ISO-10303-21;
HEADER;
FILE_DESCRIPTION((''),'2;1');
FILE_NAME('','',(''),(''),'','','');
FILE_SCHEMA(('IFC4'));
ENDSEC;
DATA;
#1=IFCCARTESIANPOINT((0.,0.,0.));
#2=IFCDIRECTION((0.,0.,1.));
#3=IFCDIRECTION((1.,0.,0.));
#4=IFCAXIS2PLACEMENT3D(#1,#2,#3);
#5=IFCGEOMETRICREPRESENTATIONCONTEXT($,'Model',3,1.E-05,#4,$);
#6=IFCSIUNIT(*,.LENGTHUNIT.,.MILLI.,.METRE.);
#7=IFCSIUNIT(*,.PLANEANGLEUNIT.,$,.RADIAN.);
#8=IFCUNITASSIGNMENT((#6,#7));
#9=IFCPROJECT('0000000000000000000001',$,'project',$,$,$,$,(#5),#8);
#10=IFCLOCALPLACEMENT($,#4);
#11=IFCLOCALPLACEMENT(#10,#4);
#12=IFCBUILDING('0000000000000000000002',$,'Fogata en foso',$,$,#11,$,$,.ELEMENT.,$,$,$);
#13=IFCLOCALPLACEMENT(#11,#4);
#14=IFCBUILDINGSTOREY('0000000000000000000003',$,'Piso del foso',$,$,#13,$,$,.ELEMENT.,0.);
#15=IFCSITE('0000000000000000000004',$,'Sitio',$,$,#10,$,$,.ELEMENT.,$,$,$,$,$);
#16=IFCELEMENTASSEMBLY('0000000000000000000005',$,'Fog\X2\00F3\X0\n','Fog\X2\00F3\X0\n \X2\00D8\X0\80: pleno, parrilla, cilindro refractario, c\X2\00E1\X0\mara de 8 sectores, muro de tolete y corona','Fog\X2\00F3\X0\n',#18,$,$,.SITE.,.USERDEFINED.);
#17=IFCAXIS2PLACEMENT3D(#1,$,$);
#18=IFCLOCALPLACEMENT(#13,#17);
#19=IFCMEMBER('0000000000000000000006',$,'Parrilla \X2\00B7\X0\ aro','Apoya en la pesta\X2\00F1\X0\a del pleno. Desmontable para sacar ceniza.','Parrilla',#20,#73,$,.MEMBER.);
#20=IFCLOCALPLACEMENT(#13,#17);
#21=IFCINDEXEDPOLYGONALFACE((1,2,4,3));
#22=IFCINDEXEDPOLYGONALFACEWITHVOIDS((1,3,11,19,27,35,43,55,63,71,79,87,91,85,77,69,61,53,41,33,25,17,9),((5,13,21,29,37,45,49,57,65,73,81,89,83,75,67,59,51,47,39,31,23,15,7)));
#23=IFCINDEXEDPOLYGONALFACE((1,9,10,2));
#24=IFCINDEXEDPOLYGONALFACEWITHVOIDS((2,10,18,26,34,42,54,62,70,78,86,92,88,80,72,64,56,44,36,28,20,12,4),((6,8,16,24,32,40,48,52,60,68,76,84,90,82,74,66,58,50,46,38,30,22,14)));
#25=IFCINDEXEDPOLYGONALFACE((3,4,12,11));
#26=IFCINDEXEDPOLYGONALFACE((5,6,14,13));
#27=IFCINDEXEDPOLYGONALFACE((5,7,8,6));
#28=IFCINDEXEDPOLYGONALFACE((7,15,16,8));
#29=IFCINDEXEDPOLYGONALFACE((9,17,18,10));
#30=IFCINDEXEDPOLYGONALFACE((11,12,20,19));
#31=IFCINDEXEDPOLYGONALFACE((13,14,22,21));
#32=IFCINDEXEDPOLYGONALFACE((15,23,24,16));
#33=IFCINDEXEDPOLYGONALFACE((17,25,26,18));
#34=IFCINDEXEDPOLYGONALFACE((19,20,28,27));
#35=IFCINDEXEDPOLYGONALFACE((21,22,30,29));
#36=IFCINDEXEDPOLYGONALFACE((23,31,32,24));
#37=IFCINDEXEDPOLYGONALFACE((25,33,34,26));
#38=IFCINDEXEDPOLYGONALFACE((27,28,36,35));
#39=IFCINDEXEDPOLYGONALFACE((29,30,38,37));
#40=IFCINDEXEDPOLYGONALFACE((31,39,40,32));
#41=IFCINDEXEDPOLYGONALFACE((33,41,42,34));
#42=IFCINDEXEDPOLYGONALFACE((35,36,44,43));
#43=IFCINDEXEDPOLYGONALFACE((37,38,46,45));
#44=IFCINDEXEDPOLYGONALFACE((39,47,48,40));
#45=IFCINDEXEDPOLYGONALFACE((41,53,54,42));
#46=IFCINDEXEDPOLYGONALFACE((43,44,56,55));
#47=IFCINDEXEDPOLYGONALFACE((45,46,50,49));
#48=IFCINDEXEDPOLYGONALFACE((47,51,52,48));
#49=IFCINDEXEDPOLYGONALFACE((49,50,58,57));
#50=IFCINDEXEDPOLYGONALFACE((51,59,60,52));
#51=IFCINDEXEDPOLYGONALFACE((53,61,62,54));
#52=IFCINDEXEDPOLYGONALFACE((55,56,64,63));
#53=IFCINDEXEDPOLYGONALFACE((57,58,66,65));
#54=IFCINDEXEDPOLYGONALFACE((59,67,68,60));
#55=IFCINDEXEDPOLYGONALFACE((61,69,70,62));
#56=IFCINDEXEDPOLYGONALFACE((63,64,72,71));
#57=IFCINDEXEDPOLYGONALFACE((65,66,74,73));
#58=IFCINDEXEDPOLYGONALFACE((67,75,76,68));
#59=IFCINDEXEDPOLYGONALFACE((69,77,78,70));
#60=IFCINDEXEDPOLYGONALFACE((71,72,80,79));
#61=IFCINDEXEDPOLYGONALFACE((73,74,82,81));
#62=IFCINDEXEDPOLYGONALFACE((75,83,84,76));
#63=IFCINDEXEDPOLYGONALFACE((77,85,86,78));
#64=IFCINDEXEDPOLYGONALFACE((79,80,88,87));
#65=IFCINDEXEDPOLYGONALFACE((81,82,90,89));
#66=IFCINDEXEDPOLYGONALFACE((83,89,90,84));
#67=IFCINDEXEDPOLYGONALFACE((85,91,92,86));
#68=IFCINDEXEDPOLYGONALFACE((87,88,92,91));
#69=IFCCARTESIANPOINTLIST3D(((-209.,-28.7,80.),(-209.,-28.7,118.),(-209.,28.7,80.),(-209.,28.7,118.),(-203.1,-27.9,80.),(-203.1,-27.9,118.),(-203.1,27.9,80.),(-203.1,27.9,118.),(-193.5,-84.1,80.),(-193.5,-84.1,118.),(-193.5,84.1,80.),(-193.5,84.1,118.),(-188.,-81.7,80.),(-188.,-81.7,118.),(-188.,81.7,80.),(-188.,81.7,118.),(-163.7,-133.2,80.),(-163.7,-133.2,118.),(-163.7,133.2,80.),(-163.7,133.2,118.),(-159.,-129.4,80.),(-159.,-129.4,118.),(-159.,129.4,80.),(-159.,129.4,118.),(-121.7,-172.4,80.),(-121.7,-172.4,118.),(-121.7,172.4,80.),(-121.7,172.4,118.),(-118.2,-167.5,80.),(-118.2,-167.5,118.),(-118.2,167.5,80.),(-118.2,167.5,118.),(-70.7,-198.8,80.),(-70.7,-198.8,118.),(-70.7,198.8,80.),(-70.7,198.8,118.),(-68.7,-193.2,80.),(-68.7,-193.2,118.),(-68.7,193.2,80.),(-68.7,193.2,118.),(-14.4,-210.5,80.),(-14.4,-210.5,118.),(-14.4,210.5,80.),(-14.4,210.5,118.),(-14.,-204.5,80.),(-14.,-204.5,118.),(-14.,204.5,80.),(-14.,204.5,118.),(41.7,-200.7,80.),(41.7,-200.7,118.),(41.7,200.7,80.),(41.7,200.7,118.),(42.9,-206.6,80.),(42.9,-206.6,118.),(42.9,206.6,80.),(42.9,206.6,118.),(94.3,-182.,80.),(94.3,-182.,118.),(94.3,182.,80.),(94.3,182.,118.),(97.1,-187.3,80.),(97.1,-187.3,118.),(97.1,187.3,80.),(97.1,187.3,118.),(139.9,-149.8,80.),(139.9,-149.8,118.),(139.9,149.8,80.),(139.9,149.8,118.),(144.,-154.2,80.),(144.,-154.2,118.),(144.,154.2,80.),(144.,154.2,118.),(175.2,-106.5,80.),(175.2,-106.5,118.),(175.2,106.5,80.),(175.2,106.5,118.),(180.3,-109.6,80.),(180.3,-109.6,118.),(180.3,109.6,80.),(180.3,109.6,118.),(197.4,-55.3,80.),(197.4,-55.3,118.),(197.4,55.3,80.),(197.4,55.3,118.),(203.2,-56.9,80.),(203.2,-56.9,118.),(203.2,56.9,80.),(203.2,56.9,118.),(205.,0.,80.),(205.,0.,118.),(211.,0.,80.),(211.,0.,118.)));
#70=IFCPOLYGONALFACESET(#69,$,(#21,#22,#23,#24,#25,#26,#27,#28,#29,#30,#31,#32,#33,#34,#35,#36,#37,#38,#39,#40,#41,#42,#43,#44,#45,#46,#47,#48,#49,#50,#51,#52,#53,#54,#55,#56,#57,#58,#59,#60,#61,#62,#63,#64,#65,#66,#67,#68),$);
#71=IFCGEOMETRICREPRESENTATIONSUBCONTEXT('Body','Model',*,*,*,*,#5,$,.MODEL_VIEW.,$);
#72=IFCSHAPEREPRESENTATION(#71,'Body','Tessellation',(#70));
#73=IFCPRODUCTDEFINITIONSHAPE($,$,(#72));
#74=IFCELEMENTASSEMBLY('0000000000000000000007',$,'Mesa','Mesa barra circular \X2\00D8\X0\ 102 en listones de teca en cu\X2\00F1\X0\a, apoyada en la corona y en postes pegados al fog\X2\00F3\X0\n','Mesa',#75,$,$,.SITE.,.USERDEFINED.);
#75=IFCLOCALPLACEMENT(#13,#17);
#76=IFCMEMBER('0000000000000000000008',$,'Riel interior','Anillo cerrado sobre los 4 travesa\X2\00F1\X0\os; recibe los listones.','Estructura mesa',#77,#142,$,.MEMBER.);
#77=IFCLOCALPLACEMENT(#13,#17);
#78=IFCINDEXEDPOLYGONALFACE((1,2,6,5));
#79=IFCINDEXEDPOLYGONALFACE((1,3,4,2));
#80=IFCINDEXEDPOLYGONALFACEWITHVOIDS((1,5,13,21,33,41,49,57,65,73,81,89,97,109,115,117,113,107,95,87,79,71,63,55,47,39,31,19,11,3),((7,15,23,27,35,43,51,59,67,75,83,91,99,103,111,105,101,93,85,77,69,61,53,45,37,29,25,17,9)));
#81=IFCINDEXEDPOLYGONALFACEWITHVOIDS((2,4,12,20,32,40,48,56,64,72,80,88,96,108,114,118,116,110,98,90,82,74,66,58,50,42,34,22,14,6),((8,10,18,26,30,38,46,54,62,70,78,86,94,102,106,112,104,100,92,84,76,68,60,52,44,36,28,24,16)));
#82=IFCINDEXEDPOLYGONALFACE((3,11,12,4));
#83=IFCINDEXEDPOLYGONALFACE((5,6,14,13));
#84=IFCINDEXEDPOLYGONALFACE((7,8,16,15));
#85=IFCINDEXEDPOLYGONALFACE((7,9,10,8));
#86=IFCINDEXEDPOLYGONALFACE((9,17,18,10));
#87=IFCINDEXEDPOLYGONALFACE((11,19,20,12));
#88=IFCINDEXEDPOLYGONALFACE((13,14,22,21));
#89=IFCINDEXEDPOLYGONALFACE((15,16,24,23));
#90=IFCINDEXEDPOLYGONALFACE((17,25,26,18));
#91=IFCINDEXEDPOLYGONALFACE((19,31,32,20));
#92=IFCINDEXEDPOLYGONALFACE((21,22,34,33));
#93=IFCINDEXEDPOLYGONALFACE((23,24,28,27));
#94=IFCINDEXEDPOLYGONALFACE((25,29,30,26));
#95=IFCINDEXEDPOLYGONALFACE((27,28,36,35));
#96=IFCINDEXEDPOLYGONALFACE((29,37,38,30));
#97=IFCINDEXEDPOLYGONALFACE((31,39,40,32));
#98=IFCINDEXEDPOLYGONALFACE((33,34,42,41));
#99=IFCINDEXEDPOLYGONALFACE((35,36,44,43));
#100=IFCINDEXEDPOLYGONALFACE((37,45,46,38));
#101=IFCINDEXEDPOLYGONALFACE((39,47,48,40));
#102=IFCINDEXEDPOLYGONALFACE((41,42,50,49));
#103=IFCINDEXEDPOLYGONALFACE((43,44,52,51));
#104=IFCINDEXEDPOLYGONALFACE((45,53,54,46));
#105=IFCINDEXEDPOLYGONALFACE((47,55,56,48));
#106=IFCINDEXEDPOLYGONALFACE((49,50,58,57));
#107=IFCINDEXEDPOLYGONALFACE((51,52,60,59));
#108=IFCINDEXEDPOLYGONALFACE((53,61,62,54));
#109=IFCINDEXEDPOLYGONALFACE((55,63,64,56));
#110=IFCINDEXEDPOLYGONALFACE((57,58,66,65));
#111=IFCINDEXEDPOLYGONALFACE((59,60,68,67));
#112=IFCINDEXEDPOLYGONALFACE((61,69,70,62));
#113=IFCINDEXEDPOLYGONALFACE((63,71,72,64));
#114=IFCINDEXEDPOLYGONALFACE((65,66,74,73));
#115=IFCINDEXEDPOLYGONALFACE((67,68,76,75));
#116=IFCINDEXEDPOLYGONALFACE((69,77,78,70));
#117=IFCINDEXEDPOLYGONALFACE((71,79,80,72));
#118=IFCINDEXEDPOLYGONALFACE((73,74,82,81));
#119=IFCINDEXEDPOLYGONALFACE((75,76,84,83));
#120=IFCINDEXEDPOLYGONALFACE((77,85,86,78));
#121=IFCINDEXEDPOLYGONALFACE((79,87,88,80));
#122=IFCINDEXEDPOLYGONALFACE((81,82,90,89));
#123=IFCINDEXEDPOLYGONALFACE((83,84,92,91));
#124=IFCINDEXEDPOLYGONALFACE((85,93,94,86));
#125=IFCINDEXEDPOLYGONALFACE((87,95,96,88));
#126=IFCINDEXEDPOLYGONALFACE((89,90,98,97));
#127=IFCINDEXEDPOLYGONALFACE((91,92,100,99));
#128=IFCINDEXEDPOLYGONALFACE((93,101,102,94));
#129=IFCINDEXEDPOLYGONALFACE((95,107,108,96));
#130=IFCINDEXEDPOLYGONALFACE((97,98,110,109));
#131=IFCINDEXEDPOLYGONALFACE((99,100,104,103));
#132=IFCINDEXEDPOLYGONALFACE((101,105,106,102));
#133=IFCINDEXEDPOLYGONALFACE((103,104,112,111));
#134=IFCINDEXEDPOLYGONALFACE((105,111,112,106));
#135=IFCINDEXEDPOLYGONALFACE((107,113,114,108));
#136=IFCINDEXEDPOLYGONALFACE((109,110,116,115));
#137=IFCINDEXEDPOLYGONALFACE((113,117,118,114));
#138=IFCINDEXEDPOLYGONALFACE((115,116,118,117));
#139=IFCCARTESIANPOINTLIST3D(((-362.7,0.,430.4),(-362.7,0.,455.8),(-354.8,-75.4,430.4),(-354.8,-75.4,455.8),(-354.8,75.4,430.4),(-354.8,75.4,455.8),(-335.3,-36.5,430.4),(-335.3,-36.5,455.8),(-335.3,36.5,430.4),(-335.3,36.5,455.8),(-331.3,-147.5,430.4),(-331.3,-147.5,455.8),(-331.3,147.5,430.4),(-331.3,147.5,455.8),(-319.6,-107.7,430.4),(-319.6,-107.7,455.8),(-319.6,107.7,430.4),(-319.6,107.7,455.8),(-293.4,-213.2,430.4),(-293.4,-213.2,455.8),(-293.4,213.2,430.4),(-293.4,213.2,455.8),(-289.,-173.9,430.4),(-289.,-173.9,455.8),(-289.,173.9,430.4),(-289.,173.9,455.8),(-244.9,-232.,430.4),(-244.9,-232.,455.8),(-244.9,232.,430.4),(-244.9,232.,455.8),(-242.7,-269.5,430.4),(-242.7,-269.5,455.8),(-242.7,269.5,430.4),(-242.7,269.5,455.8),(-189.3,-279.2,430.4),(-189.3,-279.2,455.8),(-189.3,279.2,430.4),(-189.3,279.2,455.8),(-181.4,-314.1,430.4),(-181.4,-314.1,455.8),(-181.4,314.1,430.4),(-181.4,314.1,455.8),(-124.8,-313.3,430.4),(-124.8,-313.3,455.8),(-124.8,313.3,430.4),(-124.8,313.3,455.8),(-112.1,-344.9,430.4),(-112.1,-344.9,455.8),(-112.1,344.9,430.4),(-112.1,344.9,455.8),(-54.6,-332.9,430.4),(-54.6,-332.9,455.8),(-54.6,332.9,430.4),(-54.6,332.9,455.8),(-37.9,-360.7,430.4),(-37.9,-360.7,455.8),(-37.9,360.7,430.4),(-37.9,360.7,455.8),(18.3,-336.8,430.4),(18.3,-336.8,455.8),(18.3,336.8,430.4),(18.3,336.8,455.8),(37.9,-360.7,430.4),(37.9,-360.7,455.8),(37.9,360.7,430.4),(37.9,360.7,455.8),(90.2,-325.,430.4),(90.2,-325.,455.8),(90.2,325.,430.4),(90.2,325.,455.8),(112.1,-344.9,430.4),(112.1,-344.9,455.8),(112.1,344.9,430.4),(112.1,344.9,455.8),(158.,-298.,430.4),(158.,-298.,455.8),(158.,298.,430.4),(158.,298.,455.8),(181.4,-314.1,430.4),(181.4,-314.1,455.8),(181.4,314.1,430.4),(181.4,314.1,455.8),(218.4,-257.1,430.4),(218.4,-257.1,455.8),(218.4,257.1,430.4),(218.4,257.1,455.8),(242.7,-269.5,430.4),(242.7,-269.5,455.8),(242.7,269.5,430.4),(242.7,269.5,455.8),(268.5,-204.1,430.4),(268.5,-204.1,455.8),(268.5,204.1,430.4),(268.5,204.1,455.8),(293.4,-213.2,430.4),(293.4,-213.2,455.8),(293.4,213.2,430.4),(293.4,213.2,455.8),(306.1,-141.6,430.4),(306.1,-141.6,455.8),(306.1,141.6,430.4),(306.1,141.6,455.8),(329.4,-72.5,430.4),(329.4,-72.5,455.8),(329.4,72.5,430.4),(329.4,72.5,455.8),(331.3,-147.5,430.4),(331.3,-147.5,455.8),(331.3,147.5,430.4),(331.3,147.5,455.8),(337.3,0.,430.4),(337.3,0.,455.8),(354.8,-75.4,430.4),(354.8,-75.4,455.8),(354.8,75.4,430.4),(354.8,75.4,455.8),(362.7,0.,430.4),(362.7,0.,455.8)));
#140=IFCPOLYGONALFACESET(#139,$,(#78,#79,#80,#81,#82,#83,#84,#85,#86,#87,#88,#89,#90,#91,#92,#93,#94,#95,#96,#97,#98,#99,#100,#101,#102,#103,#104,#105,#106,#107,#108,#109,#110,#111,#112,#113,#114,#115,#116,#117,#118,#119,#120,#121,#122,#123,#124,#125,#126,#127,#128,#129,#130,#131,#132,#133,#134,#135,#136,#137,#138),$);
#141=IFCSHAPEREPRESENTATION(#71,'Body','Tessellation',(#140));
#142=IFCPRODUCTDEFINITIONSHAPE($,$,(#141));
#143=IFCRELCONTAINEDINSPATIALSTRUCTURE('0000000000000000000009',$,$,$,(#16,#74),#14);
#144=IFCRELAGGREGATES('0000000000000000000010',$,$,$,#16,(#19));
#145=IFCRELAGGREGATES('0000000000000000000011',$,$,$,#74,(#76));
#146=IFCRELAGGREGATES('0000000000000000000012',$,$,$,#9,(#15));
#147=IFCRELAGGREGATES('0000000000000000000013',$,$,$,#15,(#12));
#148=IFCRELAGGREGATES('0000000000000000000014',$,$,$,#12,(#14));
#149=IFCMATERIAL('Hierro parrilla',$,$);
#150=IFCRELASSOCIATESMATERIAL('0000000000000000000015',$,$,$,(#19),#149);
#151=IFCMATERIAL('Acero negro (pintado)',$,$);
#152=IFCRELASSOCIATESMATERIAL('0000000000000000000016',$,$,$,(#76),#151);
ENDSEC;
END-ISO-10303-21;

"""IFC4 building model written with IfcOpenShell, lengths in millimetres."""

from ifc_helpers import new_model, si_unit, frame, origin_with_axes, origin_2d, place, context, subcontext, project, spatial, hollow_circle, extrude, material, element, aggregate, save


model = new_model("IFC4")

# Units and contexts
model_context = context("Model", 3, precision=1e-05, world=origin_with_axes())
body_context = subcontext(model_context, "Body", "Model", "MODEL_VIEW")
ifc_project = project(units=[si_unit("LENGTHUNIT", "METRE", prefix="MILLI"), si_unit("PLANEANGLEUNIT", "RADIAN")], contexts=[model_context])

# Site, building, storey
site_placement = place(None, origin_with_axes())
site = spatial("IfcSite", under=ifc_project, at=site_placement, Name="Sitio", CompositionType="ELEMENT")
building_placement = place(site_placement, origin_with_axes())
building = spatial("IfcBuilding", under=site, at=building_placement, Name="Fogata en foso", CompositionType="ELEMENT")
storey_placement = place(building_placement, origin_with_axes())
storey = spatial("IfcBuildingStorey", under=building, at=storey_placement, Name="Piso del foso", CompositionType="ELEMENT", Elevation=0.0)

# Element assembly, member
assembly_1_placement = place(storey_placement, origin_with_axes())
assembly_1 = element("IfcElementAssembly", 1, at=assembly_1_placement, inside=storey, Name="Fogón", Description="Fogón Ø80: pleno, parrilla, cilindro refractario, cámara de 8 sectores, muro de tolete y corona", ObjectType="Fogón", AssemblyPlace="SITE", PredefinedType="USERDEFINED")
ifc_material_1 = material(Name="Hierro parrilla")
member_1_placement = place(storey_placement, frame((0.0, 0.0, 80.0), z_axis=(0.0, 0.0, 1.0), x_axis=(1.0, 0.0, 0.0)))
member_1 = element("IfcMember", 2, at=member_1_placement, material=ifc_material_1, Name="Parrilla · aro", Description="Apoya en la pestaña del pleno. Desmontable para sacar ceniza.", ObjectType="Parrilla", PredefinedType="MEMBER", context=body_context, shape_type="SweptSolid", body=[
    extrude(hollow_circle(Radius=211.0, WallThickness=6.0, at=origin_2d()), origin_with_axes(), (0.0, 0.0, 1.0), 38.0),
])

# Element assembly, member
assembly_2_placement = place(storey_placement, origin_with_axes())
assembly_2 = element("IfcElementAssembly", 3, at=assembly_2_placement, inside=storey, Name="Mesa", Description="Mesa barra circular Ø 102 en listones de teca en cuña, apoyada en la corona y en postes pegados al fogón", ObjectType="Mesa", AssemblyPlace="SITE", PredefinedType="USERDEFINED")
ifc_material_2 = material(Name="Acero negro (pintado)")
member_2_placement = place(storey_placement, frame((0.0, 0.0, 430.4), z_axis=(0.0, 0.0, 1.0), x_axis=(1.0, 0.0, 0.0)))
member_2 = element("IfcMember", 4, at=member_2_placement, material=ifc_material_2, Name="Riel interior", Description="Anillo cerrado sobre los 4 travesaños; recibe los listones.", ObjectType="Estructura mesa", PredefinedType="MEMBER", context=body_context, shape_type="SweptSolid", body=[
    extrude(hollow_circle(Radius=362.7, WallThickness=25.4, at=origin_2d()), origin_with_axes(), (0.0, 0.0, 1.0), 25.4),
])

aggregate(assembly_1, [member_1])

aggregate(assembly_2, [member_2])

save(model, "model.ifc")
